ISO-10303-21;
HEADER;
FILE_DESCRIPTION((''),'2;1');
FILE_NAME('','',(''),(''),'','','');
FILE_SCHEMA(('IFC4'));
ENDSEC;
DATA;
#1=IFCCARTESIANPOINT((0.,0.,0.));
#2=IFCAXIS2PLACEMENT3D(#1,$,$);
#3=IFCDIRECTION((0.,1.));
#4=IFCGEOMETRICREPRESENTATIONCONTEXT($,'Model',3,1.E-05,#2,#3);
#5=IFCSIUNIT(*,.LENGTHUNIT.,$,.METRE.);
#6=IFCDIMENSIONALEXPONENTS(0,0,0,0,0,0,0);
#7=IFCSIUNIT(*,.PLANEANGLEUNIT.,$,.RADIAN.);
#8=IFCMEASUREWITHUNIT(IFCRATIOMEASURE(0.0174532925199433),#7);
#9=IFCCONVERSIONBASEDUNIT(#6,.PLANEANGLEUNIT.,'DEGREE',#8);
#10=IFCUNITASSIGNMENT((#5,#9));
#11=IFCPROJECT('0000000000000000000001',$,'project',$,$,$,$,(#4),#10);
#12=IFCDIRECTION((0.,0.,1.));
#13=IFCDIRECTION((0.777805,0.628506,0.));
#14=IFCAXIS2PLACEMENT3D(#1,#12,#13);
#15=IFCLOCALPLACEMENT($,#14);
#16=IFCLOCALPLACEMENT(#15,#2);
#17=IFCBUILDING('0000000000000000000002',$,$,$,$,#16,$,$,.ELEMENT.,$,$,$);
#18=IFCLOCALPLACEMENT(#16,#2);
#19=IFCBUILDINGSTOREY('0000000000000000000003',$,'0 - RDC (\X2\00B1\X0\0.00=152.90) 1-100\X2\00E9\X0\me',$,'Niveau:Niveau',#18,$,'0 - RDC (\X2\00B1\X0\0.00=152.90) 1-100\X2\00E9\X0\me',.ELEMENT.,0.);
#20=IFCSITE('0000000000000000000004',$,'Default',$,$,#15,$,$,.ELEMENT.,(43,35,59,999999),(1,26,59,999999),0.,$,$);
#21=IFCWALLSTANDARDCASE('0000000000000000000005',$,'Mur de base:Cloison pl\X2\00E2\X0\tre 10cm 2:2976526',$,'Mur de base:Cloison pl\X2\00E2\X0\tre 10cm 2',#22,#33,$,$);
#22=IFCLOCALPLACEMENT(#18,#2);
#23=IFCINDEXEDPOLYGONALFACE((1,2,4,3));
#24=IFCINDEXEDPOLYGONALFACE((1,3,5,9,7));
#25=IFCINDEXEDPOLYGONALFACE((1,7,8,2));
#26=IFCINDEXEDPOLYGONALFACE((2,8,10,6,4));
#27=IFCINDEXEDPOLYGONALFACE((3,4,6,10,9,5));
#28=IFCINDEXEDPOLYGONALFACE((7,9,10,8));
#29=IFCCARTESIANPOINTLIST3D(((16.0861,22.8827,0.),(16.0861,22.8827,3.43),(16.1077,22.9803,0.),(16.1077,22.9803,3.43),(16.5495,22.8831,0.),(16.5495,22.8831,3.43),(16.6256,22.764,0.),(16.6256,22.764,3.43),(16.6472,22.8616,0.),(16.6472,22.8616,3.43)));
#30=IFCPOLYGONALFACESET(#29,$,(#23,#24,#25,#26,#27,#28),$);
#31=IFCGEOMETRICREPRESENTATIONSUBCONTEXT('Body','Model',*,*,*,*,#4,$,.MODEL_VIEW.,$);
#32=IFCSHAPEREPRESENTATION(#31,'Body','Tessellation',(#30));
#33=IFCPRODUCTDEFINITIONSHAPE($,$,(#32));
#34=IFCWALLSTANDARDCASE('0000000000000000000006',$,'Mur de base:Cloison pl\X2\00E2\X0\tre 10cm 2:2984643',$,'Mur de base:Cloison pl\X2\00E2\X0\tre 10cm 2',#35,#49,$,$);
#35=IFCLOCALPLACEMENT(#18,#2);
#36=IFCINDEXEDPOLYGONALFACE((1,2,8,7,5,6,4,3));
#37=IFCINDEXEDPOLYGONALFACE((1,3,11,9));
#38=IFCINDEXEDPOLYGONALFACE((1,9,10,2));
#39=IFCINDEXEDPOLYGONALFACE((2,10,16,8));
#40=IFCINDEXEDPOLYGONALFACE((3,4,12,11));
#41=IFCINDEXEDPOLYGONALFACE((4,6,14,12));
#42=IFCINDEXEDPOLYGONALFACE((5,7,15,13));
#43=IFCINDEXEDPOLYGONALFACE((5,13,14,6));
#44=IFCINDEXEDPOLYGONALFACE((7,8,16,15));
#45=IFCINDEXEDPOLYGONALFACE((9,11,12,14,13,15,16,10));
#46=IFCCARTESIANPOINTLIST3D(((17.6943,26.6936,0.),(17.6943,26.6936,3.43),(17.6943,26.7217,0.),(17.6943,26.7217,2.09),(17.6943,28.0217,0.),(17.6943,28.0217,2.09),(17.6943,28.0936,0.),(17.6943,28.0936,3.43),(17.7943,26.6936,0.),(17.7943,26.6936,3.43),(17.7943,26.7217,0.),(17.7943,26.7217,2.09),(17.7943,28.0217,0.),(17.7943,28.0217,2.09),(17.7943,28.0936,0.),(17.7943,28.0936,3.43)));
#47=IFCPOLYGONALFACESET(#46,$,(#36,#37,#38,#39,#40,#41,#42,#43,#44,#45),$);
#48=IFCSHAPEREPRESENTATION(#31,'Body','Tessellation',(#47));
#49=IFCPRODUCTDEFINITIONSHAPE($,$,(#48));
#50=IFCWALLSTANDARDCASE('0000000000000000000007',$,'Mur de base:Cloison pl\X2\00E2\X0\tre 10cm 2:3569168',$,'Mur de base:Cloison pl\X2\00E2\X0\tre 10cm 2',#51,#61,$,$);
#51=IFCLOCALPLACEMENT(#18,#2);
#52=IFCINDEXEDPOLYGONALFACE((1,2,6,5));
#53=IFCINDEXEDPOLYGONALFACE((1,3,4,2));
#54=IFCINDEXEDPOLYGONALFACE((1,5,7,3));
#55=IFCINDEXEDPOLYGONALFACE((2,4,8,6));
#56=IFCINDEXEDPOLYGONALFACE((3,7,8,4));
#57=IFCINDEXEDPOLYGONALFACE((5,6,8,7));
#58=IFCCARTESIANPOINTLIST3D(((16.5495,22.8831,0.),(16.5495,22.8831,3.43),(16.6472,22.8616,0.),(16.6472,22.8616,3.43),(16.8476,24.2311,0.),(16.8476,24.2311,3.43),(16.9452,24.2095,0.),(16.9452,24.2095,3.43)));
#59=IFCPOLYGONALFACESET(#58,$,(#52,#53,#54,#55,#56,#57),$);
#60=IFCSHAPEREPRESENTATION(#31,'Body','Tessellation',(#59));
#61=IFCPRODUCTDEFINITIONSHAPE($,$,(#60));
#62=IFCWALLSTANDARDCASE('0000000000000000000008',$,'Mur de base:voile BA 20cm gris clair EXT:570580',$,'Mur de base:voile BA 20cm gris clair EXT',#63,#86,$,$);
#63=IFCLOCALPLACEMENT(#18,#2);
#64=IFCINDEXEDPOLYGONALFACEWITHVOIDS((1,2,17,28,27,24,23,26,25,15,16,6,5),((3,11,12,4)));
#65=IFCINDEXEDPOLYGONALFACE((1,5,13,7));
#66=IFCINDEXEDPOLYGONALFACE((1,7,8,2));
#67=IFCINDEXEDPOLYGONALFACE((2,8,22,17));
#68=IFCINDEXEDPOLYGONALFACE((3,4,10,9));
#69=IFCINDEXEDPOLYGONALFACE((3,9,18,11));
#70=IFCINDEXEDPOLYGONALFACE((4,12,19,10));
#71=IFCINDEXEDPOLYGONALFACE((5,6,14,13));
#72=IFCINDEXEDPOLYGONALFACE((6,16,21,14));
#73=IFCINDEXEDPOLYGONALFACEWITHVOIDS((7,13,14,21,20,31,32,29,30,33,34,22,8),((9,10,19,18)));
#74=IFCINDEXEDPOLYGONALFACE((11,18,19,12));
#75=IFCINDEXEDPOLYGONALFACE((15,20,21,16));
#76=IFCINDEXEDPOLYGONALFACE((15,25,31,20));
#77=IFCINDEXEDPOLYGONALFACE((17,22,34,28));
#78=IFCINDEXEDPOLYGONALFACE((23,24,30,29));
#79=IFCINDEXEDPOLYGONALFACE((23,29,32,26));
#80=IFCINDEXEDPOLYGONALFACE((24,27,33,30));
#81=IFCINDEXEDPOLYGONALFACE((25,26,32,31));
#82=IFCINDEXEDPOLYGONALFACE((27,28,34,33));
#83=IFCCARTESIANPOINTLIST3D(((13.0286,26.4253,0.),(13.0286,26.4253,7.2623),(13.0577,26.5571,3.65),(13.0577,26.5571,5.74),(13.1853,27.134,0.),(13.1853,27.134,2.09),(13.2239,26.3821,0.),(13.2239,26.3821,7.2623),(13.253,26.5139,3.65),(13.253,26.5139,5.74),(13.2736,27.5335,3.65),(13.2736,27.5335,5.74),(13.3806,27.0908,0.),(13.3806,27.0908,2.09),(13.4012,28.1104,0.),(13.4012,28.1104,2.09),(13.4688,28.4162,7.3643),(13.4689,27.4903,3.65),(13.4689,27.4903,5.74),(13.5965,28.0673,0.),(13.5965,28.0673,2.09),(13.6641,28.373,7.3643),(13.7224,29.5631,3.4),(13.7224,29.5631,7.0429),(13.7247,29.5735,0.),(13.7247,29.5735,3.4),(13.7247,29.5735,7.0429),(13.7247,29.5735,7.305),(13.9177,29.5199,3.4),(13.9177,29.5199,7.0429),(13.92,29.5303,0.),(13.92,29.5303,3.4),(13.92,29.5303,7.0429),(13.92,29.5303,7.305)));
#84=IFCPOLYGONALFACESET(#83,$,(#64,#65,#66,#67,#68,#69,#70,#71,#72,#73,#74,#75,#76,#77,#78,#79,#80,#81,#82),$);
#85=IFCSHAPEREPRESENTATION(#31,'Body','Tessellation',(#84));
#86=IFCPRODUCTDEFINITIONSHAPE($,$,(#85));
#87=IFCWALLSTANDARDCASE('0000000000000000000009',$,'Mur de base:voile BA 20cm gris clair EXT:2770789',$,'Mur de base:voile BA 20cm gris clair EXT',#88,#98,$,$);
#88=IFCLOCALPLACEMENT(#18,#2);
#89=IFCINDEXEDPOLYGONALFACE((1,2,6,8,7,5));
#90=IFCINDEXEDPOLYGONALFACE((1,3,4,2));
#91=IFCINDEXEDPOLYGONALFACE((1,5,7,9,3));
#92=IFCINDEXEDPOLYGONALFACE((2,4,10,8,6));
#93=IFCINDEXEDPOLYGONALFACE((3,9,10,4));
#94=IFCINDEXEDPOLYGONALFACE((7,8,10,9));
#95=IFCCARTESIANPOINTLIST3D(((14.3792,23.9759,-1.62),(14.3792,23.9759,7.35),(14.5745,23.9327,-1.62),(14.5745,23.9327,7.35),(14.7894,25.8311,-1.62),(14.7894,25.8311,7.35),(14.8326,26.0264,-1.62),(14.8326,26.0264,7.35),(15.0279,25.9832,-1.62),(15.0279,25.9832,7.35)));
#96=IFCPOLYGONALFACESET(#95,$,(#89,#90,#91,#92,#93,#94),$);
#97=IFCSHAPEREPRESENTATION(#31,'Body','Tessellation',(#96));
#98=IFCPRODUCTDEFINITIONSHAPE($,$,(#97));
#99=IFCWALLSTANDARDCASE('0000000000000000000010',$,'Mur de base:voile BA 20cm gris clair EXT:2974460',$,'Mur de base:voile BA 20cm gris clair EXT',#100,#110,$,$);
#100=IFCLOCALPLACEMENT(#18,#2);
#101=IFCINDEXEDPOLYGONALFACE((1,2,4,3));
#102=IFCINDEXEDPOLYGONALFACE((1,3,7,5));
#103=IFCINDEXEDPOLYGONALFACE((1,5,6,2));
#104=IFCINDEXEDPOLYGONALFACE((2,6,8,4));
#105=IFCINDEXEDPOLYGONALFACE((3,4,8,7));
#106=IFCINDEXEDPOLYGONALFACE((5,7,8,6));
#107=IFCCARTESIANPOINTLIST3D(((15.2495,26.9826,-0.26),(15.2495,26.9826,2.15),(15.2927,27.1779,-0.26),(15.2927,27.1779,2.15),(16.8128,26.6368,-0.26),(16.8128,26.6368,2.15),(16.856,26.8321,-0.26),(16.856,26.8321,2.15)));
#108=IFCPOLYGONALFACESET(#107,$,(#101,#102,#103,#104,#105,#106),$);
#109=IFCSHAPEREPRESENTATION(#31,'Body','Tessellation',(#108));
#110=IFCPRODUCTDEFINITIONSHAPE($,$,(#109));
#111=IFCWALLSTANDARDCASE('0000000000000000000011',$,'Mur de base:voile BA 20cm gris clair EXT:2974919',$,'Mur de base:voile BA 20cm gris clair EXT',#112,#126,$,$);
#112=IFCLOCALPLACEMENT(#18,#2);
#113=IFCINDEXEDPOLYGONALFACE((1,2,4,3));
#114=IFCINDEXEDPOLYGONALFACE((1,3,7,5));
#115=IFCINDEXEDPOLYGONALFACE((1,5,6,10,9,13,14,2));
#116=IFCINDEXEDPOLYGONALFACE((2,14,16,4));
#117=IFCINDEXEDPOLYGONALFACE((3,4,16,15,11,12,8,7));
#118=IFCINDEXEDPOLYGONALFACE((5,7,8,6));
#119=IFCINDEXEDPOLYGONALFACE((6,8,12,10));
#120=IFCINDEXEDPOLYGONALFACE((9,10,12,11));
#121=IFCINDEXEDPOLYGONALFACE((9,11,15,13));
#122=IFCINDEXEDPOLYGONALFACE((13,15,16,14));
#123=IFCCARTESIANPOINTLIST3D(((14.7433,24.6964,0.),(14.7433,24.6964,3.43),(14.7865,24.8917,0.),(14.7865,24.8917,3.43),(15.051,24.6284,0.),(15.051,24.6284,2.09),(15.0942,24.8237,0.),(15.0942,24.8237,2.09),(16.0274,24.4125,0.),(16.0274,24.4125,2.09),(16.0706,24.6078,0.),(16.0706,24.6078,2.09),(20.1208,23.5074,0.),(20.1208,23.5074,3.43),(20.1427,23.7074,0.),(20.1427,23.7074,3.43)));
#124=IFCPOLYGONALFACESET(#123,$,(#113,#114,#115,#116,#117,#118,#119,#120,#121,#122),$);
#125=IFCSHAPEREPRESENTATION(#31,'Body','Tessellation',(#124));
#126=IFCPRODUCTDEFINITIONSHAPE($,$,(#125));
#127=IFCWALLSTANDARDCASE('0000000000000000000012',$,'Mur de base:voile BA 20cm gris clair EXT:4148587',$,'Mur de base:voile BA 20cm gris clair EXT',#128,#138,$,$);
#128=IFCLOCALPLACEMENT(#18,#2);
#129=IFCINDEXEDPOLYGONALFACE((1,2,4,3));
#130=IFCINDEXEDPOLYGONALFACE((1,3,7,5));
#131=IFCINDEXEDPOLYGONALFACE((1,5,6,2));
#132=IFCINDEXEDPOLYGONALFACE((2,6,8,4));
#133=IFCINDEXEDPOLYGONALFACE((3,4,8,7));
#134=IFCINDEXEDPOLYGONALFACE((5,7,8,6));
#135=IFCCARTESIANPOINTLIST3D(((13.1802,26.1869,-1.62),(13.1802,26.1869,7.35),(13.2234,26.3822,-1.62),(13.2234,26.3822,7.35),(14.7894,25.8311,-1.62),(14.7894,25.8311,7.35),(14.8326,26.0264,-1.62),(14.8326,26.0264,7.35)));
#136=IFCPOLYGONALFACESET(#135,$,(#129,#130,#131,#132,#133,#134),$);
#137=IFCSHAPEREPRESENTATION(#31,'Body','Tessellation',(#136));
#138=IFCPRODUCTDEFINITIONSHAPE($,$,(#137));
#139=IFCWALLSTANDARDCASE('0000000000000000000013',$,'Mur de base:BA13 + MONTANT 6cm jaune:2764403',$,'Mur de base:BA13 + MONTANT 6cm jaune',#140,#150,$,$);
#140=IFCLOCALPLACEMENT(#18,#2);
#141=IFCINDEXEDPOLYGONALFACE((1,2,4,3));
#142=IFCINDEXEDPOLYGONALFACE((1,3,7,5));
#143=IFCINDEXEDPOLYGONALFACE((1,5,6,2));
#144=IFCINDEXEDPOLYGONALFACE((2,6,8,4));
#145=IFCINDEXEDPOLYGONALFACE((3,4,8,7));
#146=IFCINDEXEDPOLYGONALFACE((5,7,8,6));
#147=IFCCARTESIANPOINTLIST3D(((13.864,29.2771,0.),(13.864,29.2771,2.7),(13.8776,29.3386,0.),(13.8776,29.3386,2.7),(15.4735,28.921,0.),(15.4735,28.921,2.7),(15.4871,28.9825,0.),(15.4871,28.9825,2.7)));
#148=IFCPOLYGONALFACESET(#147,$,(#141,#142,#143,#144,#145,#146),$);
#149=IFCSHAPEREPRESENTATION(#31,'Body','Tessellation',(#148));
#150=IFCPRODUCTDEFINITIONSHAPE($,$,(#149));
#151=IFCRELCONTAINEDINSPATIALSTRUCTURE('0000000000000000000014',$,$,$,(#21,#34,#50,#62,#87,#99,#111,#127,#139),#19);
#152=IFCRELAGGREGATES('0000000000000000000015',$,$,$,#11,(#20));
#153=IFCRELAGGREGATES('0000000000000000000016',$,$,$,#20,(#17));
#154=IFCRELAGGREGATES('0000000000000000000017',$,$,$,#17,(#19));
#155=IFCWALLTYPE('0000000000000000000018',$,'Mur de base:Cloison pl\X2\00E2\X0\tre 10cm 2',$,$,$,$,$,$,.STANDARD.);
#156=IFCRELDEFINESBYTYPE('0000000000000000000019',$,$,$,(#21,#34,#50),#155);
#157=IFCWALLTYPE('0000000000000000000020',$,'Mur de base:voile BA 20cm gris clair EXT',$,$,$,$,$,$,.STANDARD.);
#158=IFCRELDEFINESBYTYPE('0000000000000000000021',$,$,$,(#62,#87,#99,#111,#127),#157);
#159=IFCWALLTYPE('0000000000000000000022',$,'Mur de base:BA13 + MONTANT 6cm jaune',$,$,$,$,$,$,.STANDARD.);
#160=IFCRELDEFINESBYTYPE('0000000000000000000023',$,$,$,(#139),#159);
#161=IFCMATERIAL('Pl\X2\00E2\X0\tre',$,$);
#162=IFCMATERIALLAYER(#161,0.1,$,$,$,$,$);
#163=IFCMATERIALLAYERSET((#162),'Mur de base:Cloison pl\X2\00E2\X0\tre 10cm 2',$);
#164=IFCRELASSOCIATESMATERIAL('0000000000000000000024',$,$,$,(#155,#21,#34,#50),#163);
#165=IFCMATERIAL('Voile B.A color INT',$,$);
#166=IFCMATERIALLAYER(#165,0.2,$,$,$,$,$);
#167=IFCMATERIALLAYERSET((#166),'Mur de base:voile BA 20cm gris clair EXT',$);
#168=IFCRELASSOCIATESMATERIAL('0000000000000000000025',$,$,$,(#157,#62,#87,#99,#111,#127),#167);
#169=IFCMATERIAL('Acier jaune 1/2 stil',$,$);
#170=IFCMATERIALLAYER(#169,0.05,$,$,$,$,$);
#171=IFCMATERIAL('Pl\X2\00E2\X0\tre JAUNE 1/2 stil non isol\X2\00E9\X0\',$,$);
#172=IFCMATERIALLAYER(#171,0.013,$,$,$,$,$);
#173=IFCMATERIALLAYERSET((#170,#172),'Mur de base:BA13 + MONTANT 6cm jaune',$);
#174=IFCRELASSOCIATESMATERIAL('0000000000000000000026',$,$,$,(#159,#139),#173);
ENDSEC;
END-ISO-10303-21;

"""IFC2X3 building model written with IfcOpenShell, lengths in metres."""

from ifc_helpers import new_model, entity, si_unit, converted_unit, direction, frame, frame_2d, origin, place, context, subcontext, project, spatial, polyline, rectangle, outline, extrude, clip, bounded_halfspace, material, layer, layer_set, layer_usage, type_object, element, save


model = new_model("IFC2X3")

# Units and contexts
model_context = context("Model", 3, precision=1e-05, world=origin(), true_north=direction((0.0, 1.0)))
body_context = subcontext(model_context, "Body", "Model", "MODEL_VIEW")
ifc_project = project(units=[si_unit("LENGTHUNIT", "METRE"), converted_unit("PLANEANGLEUNIT", "DEGREE", entity("IfcRatioMeasure", 0.0174532925199433), si_unit("PLANEANGLEUNIT", "RADIAN"), dimensions=[0, 0, 0, 0, 0, 0, 0])], contexts=[model_context])

# Site, building, storey
site_placement = place(None, frame((0.0, 0.0, 0.0), z_axis=(0.0, 0.0, 1.0), x_axis=(0.777805, 0.628506, 0.0)))
site = spatial("IfcSite", under=ifc_project, at=site_placement, Name="Default", CompositionType="ELEMENT", RefLatitude=(43, 35, 59, 999999), RefLongitude=(1, 26, 59, 999999), RefElevation=0.0)
building_placement = place(site_placement, origin())
building = spatial("IfcBuilding", under=site, at=building_placement, CompositionType="ELEMENT")
storey_placement = place(building_placement, origin())
storey = spatial("IfcBuildingStorey", under=building, at=storey_placement, Name="0 - RDC (±0.00=152.90) 1-100éme", ObjectType="Niveau:Niveau", LongName="0 - RDC (±0.00=152.90) 1-100éme", CompositionType="ELEMENT", Elevation=0.0)

# Shared definitions
ifc_material_1 = material(Name="Plâtre")
ifc_layer_1 = layer(ifc_material_1, 0.1)
ifc_layer_set_1 = layer_set([ifc_layer_1], Name="Mur de base:Cloison plâtre 10cm 2")
wall_type_1 = type_object("IfcWallType", Name="Mur de base:Cloison plâtre 10cm 2", PredefinedType="STANDARD", material=ifc_layer_set_1)

# Wall
ifc_layer_usage_1 = layer_usage(ifc_layer_set_1, "AXIS2", "NEGATIVE", 0.05)
wall_1_placement = place(storey_placement, frame((16.6364, 22.8128, 0.0), z_axis=(0.0, 0.0, 1.0), x_axis=(-0.976646, 0.214854, 0.0)))
element("IfcWallStandardCase", 1, at=wall_1_placement, inside=storey, type_object=wall_type_1, material=ifc_layer_usage_1, Name="Mur de base:Cloison plâtre 10cm 2:2976526", ObjectType="Mur de base:Cloison plâtre 10cm 2", context=body_context, shape_type="SweptSolid", body=[
    extrude(outline(polyline([(0.5523, -0.05), (0.5525, 0.05), (0.0001, 0.05), (0.0, -0.05), (0.1, -0.05), (0.5523, -0.05)])), origin(), (0.0, 0.0, 1.0), 3.43),
])

# Wall, opening
ifc_layer_usage_2 = layer_usage(ifc_layer_set_1, "AXIS2", "NEGATIVE", 0.05)
wall_2_placement = place(storey_placement, frame((17.7443, 28.0936, 0.0), z_axis=(0.0, 0.0, 1.0), x_axis=(0.0, -1.0, 0.0)))
wall_2 = element("IfcWallStandardCase", 2, at=wall_2_placement, inside=storey, type_object=wall_type_1, material=ifc_layer_usage_2, Name="Mur de base:Cloison plâtre 10cm 2:2984643", ObjectType="Mur de base:Cloison plâtre 10cm 2", context=body_context, shape_type="SweptSolid", body=[
    extrude(rectangle(XDim=1.4, YDim=0.1, at=frame_2d((0.7, 0.0), x_axis=(-1.0, 0.0))), origin(), (0.0, 0.0, 1.0), 3.43),
])
opening_1_placement = place(wall_2_placement, frame((1.3719, 0.05, 0.0)))
element("IfcOpeningElement", 3, at=opening_1_placement, cuts=wall_2, ObjectType="Opening", context=body_context, shape_type="SweptSolid", body=[
    extrude(rectangle(XDim=2.09, YDim=1.3, at=frame_2d((1.045, 0.65), x_axis=(1.0, 0.0))), frame((0.0, 0.0, 0.0), z_axis=(0.0, -1.0, 0.0), x_axis=(0.0, 0.0, 1.0)), (0.0, 0.0, 1.0), 0.1),
])

# Wall
ifc_layer_usage_3 = layer_usage(ifc_layer_set_1, "AXIS2", "NEGATIVE", 0.05)
wall_3_placement = place(storey_placement, frame((16.5983, 22.8723, 0.0), z_axis=(0.0, 0.0, 1.0), x_axis=(0.2159, 0.976415, 0.0)))
element("IfcWallStandardCase", 4, at=wall_3_placement, inside=storey, type_object=wall_type_1, material=ifc_layer_usage_3, Name="Mur de base:Cloison plâtre 10cm 2:3569168", ObjectType="Mur de base:Cloison plâtre 10cm 2", context=body_context, shape_type="SweptSolid", body=[
    extrude(outline(polyline([(1.3806, -0.05), (1.3806, 0.05), (0.0, 0.05), (0.0001, -0.05), (1.3806, -0.05)])), origin(), (0.0, 0.0, 1.0), 3.43),
])

# Wall, openings
ifc_material_2 = material(Name="Voile B.A color INT")
ifc_layer_2 = layer(ifc_material_2, 0.2)
ifc_layer_set_2 = layer_set([ifc_layer_2], Name="Mur de base:voile BA 20cm gris clair EXT")
ifc_layer_usage_4 = layer_usage(ifc_layer_set_2, "AXIS2", "POSITIVE", -0.1)
wall_type_2 = type_object("IfcWallType", Name="Mur de base:voile BA 20cm gris clair EXT", PredefinedType="STANDARD", material=ifc_layer_set_2)
wall_4_placement = place(storey_placement, frame((13.8223, 29.5519, 0.0), z_axis=(0.0, 0.0, 1.0), x_axis=(-0.2159, -0.976415, 0.0)))
wall_4 = element("IfcWallStandardCase", 5, at=wall_4_placement, inside=storey, type_object=wall_type_2, material=ifc_layer_usage_4, Name="Mur de base:voile BA 20cm gris clair EXT:570580", ObjectType="Mur de base:voile BA 20cm gris clair EXT", context=body_context, shape_type="Clipping", body=[
    clip(clip(clip(extrude(rectangle(XDim=3.2243, YDim=0.2, at=frame_2d((1.6121, 0.0), x_axis=(-1.0, 0.0))), origin(), (0.0, 0.0, 1.0), 7.3643), bounded_halfspace(frame((0.0, 0.1, 7.305), z_axis=(-0.049938, 0.0, 0.998752), x_axis=(0.0, -1.0, 0.0)), False, frame((0.0, 0.1, 7.305)), polyline([(0.0, 0.0), (0.0, -0.2), (1.1853, -0.2), (1.1853, 0.0), (0.0, 0.0)]))), bounded_halfspace(frame((1.1853, -0.1, 7.3643), z_axis=(0.049938, 0.0, 0.998752), x_axis=(0.0, 1.0, 0.0)), False, frame((1.1853, -0.1, 7.3643)), polyline([(0.0, 0.0), (2.039, 0.0), (2.039, 0.2), (0.0, 0.2), (0.0, 0.0)]))), bounded_halfspace(frame((0.0107, 0.1, 3.4), z_axis=(1.0, 0.0, 0.0), x_axis=(0.0, 1.0, 0.0)), True, frame((0.0107, 0.1, 3.4), z_axis=(1.0, 0.0, 0.0), x_axis=(0.0, 1.0, 0.0)), polyline([(0.0, 0.0), (0.0, 3.6429), (-0.2, 3.6429), (-0.2, 0.0), (0.0, 0.0)]))),
])
opening_2_placement = place(wall_4_placement, frame((2.4984, 0.1, 0.0)))
element("IfcOpeningElement", 6, at=opening_2_placement, cuts=wall_4, ObjectType="Opening", context=body_context, shape_type="SweptSolid", body=[
    extrude(rectangle(XDim=2.09, YDim=1.0, at=frame_2d((1.045, 0.5), x_axis=(1.0, 0.0))), frame((0.0, 0.0, 0.0), z_axis=(0.0, -1.0, 0.0), x_axis=(0.0, 0.0, 1.0)), (0.0, 0.0, 1.0), 0.2),
])
opening_3_placement = place(wall_4_placement, frame((2.0893, -0.1, 3.65)))
element("IfcOpeningElement", 7, at=opening_3_placement, cuts=wall_4, ObjectType="Opening", context=body_context, shape_type="SweptSolid", body=[
    extrude(rectangle(XDim=2.09, YDim=1.0, at=frame_2d((1.045, 0.5), x_axis=(1.0, 0.0))), frame((0.0, 0.0, 0.0), z_axis=(0.0, 1.0, 0.0), x_axis=(0.0, 0.0, 1.0)), (0.0, 0.0, 1.0), 0.2),
])

# Walls
ifc_layer_usage_5 = layer_usage(ifc_layer_set_2, "AXIS2", "NEGATIVE", 0.1)
wall_5_placement = place(storey_placement, frame((14.9302, 26.0048, -1.62), z_axis=(0.0, 0.0, 1.0), x_axis=(-0.2159, -0.976415, 0.0)))
element("IfcWallStandardCase", 8, at=wall_5_placement, inside=storey, type_object=wall_type_2, material=ifc_layer_usage_5, Name="Mur de base:voile BA 20cm gris clair EXT:2770789", ObjectType="Mur de base:voile BA 20cm gris clair EXT", context=body_context, shape_type="SweptSolid", body=[
    extrude(outline(polyline([(2.1, -0.1), (2.1, 0.1), (0.0, 0.1), (0.0, -0.1), (0.2, -0.1), (2.1, -0.1)])), origin(), (0.0, 0.0, 1.0), 8.97),
])
ifc_layer_usage_6 = layer_usage(ifc_layer_set_2, "AXIS2", "POSITIVE", -0.1)
wall_6_placement = place(storey_placement, frame((15.2711, 27.0803, -0.26), z_axis=(0.0, 0.0, 1.0), x_axis=(0.976397, -0.215985, 0.0)))
element("IfcWallStandardCase", 9, at=wall_6_placement, inside=storey, type_object=wall_type_2, material=ifc_layer_usage_6, Name="Mur de base:voile BA 20cm gris clair EXT:2974460", ObjectType="Mur de base:voile BA 20cm gris clair EXT", context=body_context, shape_type="SweptSolid", body=[
    extrude(outline(polyline([(1.601, -0.1), (1.601, 0.1), (0.0, 0.1), (0.0, -0.1), (1.601, -0.1)])), origin(), (0.0, 0.0, 1.0), 2.41),
])

# Wall, openings
ifc_layer_usage_7 = layer_usage(ifc_layer_set_2, "AXIS2", "POSITIVE", -0.1)
wall_7_placement = place(storey_placement, frame((14.7649, 24.794, 0.0), z_axis=(0.0, 0.0, 1.0), x_axis=(0.976415, -0.2159, 0.0)))
wall_7 = element("IfcWallStandardCase", 10, at=wall_7_placement, inside=storey, type_object=wall_type_2, material=ifc_layer_usage_7, Name="Mur de base:voile BA 20cm gris clair EXT:2974919", ObjectType="Mur de base:voile BA 20cm gris clair EXT", context=body_context, shape_type="SweptSolid", body=[
    extrude(outline(polyline([(0.0, -0.1), (1.6028, -0.1), (1.7028, -0.1), (2.1551, -0.1), (2.2551, -0.1), (5.5074, -0.1), (5.4855, 0.1), (0.0, 0.1), (0.0, -0.1)])), origin(), (0.0, 0.0, 1.0), 3.43),
])
opening_4_placement = place(wall_7_placement, origin())
element("IfcOpeningElement", 11, at=opening_4_placement, cuts=wall_7, ObjectType="Opening", context=body_context, shape_type="SweptSolid", body=[
    extrude(rectangle(XDim=2.09, YDim=0.1, at=frame_2d((0.0, 0.0), x_axis=(0.0, 1.0))), frame((1.6527, -1.451, 1.045), z_axis=(0.000087, 1.0, 0.0), x_axis=(1.0, -0.000087, 0.0)), (0.0, 0.0, 1.0), 1.3),
])
opening_5_placement = place(wall_7_placement, frame((0.3151, -0.1, 0.0)))
element("IfcOpeningElement", 12, at=opening_5_placement, cuts=wall_7, ObjectType="Opening", context=body_context, shape_type="SweptSolid", body=[
    extrude(rectangle(XDim=2.09, YDim=1.0, at=frame_2d((1.045, 0.5), x_axis=(1.0, 0.0))), frame((0.0, 0.0, 0.0), z_axis=(0.0, 1.0, 0.0), x_axis=(0.0, 0.0, 1.0)), (0.0, 0.0, 1.0), 0.2),
])

# Walls
ifc_layer_usage_8 = layer_usage(ifc_layer_set_2, "AXIS2", "NEGATIVE", 0.1)
wall_8_placement = place(storey_placement, frame((14.811, 25.9287, -1.62), z_axis=(0.0, 0.0, 1.0), x_axis=(-0.976415, 0.2159, 0.0)))
element("IfcWallStandardCase", 13, at=wall_8_placement, inside=storey, type_object=wall_type_2, material=ifc_layer_usage_8, Name="Mur de base:voile BA 20cm gris clair EXT:4148587", ObjectType="Mur de base:voile BA 20cm gris clair EXT", context=body_context, shape_type="SweptSolid", body=[
    extrude(rectangle(XDim=1.648, YDim=0.2, at=frame_2d((0.824, 0.0), x_axis=(-1.0, 0.0))), origin(), (0.0, 0.0, 1.0), 8.97),
])
ifc_material_3 = material(Name="Acier jaune 1/2 stil")
ifc_layer_3 = layer(ifc_material_3, 0.05)
ifc_material_4 = material(Name="Plâtre JAUNE 1/2 stil non isolé")
ifc_layer_4 = layer(ifc_material_4, 0.013)
ifc_layer_set_3 = layer_set([ifc_layer_3, ifc_layer_4], Name="Mur de base:BA13 + MONTANT 6cm jaune")
ifc_layer_usage_9 = layer_usage(ifc_layer_set_3, "AXIS2", "NEGATIVE", 0.0315)
wall_type_3 = type_object("IfcWallType", Name="Mur de base:BA13 + MONTANT 6cm jaune", PredefinedType="STANDARD", material=ifc_layer_set_3)
wall_9_placement = place(storey_placement, frame((13.8708, 29.3078, 0.0), z_axis=(0.0, 0.0, 1.0), x_axis=(0.976392, -0.216005, 0.0)))
element("IfcWallStandardCase", 14, at=wall_9_placement, inside=storey, type_object=wall_type_3, material=ifc_layer_usage_9, Name="Mur de base:BA13 + MONTANT 6cm jaune:2764403", ObjectType="Mur de base:BA13 + MONTANT 6cm jaune", context=body_context, shape_type="SweptSolid", body=[
    extrude(outline(polyline([(1.6485, -0.0315), (1.6485, 0.0315), (0.0, 0.0315), (0.0, -0.0315), (1.6485, -0.0315)])), origin(), (0.0, 0.0, 1.0), 2.7),
])

save(model, "model.ifc")
